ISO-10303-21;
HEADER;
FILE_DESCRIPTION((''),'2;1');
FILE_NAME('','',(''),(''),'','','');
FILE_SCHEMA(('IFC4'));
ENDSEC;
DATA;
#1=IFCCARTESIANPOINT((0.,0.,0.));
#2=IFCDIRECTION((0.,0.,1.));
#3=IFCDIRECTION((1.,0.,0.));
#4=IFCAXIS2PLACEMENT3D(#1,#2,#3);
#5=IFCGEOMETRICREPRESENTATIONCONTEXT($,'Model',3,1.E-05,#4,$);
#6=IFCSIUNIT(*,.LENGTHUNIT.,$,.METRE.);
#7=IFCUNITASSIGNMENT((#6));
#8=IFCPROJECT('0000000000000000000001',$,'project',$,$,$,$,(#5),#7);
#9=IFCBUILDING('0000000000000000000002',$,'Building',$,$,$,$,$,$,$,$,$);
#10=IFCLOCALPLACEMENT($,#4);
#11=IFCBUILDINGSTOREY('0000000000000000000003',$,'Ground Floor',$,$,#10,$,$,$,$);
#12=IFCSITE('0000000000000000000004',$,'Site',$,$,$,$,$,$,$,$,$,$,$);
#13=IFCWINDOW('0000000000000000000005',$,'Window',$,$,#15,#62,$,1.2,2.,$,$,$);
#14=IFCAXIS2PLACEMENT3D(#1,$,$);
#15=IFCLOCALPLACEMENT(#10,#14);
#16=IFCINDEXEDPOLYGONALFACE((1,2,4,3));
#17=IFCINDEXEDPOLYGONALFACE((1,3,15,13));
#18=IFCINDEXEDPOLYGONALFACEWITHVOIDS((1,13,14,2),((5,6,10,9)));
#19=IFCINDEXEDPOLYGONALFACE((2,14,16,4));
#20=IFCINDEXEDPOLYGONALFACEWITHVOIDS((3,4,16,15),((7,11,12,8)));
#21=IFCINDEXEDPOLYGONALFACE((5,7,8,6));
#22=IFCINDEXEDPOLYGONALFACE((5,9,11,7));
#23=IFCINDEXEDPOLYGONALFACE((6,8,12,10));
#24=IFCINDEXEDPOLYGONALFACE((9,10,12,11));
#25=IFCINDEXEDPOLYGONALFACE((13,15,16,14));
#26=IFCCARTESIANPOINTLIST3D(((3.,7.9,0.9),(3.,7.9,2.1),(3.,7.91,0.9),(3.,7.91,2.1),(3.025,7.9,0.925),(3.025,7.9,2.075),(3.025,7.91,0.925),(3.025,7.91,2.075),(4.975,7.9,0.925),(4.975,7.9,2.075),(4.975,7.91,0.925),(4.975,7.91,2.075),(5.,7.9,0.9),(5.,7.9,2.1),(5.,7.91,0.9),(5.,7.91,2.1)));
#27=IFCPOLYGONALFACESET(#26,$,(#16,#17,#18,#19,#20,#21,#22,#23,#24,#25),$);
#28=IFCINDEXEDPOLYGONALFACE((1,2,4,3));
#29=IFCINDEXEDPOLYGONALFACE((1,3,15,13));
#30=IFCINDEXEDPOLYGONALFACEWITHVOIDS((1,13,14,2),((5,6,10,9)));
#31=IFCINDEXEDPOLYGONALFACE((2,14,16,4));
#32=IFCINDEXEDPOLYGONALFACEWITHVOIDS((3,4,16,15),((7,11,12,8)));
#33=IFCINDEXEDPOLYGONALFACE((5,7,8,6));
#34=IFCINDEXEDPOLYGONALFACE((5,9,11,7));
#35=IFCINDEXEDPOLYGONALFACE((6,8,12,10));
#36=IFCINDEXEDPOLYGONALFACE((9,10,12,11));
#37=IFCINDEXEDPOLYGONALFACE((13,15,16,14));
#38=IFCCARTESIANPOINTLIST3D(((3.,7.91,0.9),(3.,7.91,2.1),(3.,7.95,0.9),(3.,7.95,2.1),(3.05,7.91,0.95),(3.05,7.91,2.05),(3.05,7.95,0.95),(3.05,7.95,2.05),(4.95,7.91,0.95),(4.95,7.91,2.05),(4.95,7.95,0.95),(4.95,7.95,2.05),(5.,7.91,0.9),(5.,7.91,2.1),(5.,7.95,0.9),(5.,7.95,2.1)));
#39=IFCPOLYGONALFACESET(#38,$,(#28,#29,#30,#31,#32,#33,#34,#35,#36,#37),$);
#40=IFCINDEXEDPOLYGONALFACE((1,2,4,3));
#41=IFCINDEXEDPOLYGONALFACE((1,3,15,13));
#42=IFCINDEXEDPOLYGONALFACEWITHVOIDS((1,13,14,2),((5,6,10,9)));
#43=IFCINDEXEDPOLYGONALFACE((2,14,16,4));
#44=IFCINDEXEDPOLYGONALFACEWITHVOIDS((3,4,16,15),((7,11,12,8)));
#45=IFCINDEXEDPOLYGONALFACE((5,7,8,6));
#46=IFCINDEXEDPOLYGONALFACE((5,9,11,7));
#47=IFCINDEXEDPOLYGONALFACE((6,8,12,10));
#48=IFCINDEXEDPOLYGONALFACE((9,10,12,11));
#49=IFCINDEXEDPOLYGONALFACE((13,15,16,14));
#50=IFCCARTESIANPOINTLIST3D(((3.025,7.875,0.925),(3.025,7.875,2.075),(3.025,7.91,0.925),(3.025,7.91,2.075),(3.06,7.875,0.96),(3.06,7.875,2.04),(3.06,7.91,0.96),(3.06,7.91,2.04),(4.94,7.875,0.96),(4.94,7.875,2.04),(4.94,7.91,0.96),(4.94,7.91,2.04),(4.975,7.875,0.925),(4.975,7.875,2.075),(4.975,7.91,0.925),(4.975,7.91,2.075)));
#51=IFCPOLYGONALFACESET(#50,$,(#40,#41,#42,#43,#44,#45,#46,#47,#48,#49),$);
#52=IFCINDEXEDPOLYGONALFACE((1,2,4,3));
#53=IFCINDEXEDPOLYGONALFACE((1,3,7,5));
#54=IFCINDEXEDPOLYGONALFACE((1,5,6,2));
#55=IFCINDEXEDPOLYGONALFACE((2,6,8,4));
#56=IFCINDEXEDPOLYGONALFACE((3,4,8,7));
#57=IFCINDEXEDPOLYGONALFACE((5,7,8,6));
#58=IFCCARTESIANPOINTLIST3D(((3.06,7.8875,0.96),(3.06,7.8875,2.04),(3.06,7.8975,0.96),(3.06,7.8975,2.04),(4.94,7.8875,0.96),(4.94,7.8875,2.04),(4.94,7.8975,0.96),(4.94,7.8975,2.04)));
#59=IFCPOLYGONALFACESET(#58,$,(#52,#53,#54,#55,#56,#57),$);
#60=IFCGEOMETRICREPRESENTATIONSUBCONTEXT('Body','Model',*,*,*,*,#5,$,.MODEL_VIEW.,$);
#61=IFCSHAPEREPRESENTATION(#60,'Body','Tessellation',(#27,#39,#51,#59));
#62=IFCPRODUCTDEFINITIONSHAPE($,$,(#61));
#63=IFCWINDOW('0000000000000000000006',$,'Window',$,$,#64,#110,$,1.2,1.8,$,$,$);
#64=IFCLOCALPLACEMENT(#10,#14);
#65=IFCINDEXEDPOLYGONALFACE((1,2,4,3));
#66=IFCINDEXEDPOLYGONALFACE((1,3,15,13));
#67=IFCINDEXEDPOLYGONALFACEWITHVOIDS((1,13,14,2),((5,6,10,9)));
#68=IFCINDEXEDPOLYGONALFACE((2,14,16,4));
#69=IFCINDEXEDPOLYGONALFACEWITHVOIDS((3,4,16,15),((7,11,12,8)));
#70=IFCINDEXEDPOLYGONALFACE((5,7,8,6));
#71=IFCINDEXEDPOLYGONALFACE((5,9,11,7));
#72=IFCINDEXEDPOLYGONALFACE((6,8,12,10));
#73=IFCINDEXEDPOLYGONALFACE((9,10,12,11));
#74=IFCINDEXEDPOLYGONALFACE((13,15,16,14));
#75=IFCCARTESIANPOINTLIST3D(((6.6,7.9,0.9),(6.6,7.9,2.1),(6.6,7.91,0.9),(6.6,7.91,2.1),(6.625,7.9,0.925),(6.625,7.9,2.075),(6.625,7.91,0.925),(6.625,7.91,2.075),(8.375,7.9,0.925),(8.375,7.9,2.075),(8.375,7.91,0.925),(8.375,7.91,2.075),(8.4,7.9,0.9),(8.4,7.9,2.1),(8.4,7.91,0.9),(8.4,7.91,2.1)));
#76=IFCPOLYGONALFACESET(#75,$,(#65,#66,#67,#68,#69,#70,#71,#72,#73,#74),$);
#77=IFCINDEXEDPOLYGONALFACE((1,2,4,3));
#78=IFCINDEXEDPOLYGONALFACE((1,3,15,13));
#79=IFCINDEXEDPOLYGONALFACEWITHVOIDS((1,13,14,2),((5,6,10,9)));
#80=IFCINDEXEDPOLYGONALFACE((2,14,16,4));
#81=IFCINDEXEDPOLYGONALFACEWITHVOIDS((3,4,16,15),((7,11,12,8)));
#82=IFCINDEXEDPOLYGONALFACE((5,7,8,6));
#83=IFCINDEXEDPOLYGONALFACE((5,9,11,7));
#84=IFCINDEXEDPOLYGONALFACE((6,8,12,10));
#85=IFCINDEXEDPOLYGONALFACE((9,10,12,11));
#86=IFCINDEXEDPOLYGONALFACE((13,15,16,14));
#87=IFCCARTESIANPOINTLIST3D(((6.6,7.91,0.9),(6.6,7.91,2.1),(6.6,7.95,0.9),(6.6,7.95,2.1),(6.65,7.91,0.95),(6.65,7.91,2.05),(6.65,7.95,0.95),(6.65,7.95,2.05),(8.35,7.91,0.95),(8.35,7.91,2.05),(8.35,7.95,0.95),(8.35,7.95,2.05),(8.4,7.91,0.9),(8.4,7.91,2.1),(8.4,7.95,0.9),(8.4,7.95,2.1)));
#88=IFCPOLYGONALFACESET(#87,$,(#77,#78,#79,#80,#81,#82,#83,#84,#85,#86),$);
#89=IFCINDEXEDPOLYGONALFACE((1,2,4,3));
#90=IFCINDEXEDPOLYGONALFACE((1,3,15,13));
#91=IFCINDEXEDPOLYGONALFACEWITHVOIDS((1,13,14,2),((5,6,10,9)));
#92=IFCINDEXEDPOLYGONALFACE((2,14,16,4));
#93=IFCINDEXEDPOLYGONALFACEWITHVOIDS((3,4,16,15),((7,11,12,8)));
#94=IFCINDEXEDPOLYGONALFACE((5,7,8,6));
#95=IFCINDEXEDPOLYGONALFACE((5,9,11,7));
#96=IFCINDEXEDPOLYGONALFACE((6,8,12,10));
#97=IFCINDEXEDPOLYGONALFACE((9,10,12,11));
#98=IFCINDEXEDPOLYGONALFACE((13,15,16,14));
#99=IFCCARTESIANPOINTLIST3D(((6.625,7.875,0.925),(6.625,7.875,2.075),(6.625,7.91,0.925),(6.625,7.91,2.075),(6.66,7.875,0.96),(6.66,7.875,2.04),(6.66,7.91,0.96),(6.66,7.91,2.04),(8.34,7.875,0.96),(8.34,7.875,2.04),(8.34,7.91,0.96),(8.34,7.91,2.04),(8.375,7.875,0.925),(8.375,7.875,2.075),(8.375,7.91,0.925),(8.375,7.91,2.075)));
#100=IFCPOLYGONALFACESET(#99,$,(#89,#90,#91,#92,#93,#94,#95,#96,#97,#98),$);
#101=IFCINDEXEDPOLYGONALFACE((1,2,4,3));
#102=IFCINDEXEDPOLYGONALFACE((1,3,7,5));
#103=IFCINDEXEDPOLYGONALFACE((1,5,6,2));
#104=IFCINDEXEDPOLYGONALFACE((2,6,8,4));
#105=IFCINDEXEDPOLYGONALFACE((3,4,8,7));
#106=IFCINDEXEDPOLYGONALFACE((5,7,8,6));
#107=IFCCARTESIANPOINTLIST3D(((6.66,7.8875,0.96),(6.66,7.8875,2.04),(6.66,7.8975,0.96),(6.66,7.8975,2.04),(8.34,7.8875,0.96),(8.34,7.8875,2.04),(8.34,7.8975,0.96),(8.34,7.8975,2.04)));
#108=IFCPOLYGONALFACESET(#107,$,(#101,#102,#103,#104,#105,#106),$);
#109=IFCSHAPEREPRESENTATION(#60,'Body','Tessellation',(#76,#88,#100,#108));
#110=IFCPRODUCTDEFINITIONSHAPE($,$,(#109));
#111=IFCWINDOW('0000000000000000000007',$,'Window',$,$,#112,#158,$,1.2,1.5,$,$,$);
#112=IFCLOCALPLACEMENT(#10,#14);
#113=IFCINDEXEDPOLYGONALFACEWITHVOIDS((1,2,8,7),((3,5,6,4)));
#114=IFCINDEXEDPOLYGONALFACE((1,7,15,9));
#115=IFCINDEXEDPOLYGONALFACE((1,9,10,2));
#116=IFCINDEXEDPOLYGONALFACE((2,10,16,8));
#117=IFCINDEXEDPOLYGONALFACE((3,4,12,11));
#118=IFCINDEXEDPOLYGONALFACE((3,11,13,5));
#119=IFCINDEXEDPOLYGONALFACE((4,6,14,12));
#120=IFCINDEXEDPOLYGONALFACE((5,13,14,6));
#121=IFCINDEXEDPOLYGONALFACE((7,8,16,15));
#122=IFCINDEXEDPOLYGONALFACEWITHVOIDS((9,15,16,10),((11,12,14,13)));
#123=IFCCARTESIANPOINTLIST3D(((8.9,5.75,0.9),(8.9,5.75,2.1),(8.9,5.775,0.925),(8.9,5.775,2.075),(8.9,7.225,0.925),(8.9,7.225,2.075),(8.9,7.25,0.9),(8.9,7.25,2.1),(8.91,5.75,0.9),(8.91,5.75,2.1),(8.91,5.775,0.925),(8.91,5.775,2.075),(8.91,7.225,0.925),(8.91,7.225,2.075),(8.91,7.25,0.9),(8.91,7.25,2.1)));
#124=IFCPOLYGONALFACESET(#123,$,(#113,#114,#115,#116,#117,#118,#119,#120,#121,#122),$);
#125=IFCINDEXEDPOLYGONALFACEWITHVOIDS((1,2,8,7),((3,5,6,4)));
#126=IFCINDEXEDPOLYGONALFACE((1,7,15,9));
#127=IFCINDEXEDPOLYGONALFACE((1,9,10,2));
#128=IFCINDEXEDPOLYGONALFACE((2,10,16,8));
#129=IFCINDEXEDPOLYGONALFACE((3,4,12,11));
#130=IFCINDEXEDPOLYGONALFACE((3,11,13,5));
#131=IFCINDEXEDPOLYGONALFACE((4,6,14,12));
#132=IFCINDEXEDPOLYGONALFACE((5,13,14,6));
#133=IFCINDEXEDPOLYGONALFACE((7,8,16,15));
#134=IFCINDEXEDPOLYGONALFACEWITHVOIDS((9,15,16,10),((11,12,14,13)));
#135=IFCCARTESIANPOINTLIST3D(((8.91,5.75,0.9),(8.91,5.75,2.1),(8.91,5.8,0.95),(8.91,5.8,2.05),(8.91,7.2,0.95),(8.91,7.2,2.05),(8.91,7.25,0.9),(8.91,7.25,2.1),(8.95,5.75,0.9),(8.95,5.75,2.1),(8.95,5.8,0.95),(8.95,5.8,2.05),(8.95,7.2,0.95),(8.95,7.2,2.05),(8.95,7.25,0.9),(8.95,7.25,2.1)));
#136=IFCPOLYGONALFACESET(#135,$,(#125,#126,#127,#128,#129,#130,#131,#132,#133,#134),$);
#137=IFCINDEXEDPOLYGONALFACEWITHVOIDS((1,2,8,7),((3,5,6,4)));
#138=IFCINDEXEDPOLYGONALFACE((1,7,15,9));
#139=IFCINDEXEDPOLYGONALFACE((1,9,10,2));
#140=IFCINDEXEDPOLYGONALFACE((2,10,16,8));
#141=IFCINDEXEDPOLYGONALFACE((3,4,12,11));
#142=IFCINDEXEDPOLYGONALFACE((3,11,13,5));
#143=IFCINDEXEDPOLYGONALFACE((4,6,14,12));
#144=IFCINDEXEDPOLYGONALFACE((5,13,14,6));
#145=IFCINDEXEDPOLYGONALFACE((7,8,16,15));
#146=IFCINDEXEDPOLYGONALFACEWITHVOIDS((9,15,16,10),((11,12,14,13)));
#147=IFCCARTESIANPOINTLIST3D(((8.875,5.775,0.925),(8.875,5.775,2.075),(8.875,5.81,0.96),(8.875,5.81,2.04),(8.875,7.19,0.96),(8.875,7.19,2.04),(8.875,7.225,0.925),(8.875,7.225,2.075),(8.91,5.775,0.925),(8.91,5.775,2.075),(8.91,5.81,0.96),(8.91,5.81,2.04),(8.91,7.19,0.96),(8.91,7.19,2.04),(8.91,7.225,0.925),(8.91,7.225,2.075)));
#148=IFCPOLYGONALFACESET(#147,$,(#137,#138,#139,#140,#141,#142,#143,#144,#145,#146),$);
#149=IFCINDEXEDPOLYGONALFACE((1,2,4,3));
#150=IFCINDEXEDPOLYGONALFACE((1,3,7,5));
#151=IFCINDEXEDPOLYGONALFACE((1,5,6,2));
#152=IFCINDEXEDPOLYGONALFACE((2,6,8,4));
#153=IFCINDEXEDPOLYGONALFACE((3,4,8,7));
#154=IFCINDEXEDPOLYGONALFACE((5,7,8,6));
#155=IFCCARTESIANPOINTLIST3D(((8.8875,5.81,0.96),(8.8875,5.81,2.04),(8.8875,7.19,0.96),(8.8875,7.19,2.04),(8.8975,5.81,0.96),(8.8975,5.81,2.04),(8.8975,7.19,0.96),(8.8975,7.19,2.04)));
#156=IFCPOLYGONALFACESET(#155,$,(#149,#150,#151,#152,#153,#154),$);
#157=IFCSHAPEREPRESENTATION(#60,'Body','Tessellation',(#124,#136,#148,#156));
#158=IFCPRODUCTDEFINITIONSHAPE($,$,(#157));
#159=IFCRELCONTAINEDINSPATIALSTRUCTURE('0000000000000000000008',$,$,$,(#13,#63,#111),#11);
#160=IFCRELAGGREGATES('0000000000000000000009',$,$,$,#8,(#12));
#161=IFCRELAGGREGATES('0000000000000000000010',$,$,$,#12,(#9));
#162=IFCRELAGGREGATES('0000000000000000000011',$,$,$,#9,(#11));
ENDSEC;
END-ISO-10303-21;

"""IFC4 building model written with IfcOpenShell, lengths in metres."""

from ifc_helpers import new_model, si_unit, frame, origin_with_axes, place, context, subcontext, project, spatial, line, indexed_curve, outline, extrude, element, save


model = new_model("IFC4")

# Units and contexts
model_context = context("Model", 3, precision=1e-05, world=origin_with_axes())
body_context = subcontext(model_context, "Body", "Model", "MODEL_VIEW")
ifc_project = project(units=[si_unit("LENGTHUNIT", "METRE")], contexts=[model_context])

# Site, building, storey
site = spatial("IfcSite", under=ifc_project, Name="Site")
building = spatial("IfcBuilding", under=site, Name="Building")
storey_placement = place(None, origin_with_axes())
storey = spatial("IfcBuildingStorey", under=building, at=storey_placement, Name="Ground Floor")

# Windows
window_1_placement = place(storey_placement, frame((5.0, 8.0, 0.9), z_axis=(0.0, 0.0, 1.0), x_axis=(-1.0, 0.0, 0.0)))
element("IfcWindow", 1, at=window_1_placement, inside=storey, Name="Window", OverallHeight=1.2, OverallWidth=2.0, context=body_context, shape_type="SweptSolid", body=[
    extrude(outline(indexed_curve([(0.0, 0.0), (2.0, 0.0), (2.0, 1.2), (0.0, 1.2)], segments=[line(1, 2, 3, 4, 1)]), holes=[indexed_curve([(0.025, 0.025), (1.975, 0.025), (1.975, 1.175), (0.025, 1.175)], segments=[line(1, 2, 3, 4, 1)])]), frame((0.0, 0.09, 0.0), z_axis=(0.0, -1.0, 0.0), x_axis=(1.0, 0.0, 0.0)), (0.0, 0.0, -1.0), 0.01),
    extrude(outline(indexed_curve([(0.0, 0.0), (2.0, 0.0), (2.0, 1.2), (0.0, 1.2)], segments=[line(1, 2, 3, 4, 1)]), holes=[indexed_curve([(0.05, 0.05), (1.95, 0.05), (1.95, 1.15), (0.05, 1.15)], segments=[line(1, 2, 3, 4, 1)])]), frame((0.0, 0.05, 0.0), z_axis=(0.0, -1.0, 0.0), x_axis=(1.0, 0.0, 0.0)), (0.0, 0.0, -1.0), 0.04),
    extrude(outline(indexed_curve([(0.0, 0.0), (1.95, 0.0), (1.95, 1.15), (0.0, 1.15)], segments=[line(1, 2, 3, 4, 1)]), holes=[indexed_curve([(0.035, 0.035), (1.915, 0.035), (1.915, 1.115), (0.035, 1.115)], segments=[line(1, 2, 3, 4, 1)])]), frame((0.025, 0.09, 0.025), z_axis=(0.0, -1.0, 0.0), x_axis=(1.0, 0.0, 0.0)), (0.0, 0.0, -1.0), 0.035),
    extrude(outline(indexed_curve([(0.035, 0.035), (1.915, 0.035), (1.915, 1.115), (0.035, 1.115)], segments=[line(1, 2, 3, 4, 1)])), frame((0.025, 0.1025, 0.025), z_axis=(0.0, -1.0, 0.0), x_axis=(1.0, 0.0, 0.0)), (0.0, 0.0, -1.0), 0.01),
])
window_2_placement = place(storey_placement, frame((8.4, 8.0, 0.9), z_axis=(0.0, 0.0, 1.0), x_axis=(-1.0, 0.0, 0.0)))
element("IfcWindow", 2, at=window_2_placement, inside=storey, Name="Window", OverallHeight=1.2, OverallWidth=1.8, context=body_context, shape_type="SweptSolid", body=[
    extrude(outline(indexed_curve([(0.0, 0.0), (1.8, 0.0), (1.8, 1.2), (0.0, 1.2)], segments=[line(1, 2, 3, 4, 1)]), holes=[indexed_curve([(0.025, 0.025), (1.775, 0.025), (1.775, 1.175), (0.025, 1.175)], segments=[line(1, 2, 3, 4, 1)])]), frame((0.0, 0.09, 0.0), z_axis=(0.0, -1.0, 0.0), x_axis=(1.0, 0.0, 0.0)), (0.0, 0.0, -1.0), 0.01),
    extrude(outline(indexed_curve([(0.0, 0.0), (1.8, 0.0), (1.8, 1.2), (0.0, 1.2)], segments=[line(1, 2, 3, 4, 1)]), holes=[indexed_curve([(0.05, 0.05), (1.75, 0.05), (1.75, 1.15), (0.05, 1.15)], segments=[line(1, 2, 3, 4, 1)])]), frame((0.0, 0.05, 0.0), z_axis=(0.0, -1.0, 0.0), x_axis=(1.0, 0.0, 0.0)), (0.0, 0.0, -1.0), 0.04),
    extrude(outline(indexed_curve([(0.0, 0.0), (1.75, 0.0), (1.75, 1.15), (0.0, 1.15)], segments=[line(1, 2, 3, 4, 1)]), holes=[indexed_curve([(0.035, 0.035), (1.715, 0.035), (1.715, 1.115), (0.035, 1.115)], segments=[line(1, 2, 3, 4, 1)])]), frame((0.025, 0.09, 0.025), z_axis=(0.0, -1.0, 0.0), x_axis=(1.0, 0.0, 0.0)), (0.0, 0.0, -1.0), 0.035),
    extrude(outline(indexed_curve([(0.035, 0.035), (1.715, 0.035), (1.715, 1.115), (0.035, 1.115)], segments=[line(1, 2, 3, 4, 1)])), frame((0.025, 0.1025, 0.025), z_axis=(0.0, -1.0, 0.0), x_axis=(1.0, 0.0, 0.0)), (0.0, 0.0, -1.0), 0.01),
])
window_3_placement = place(storey_placement, frame((9.0, 5.75, 0.9), z_axis=(0.0, 0.0, 1.0), x_axis=(0.0, 1.0, 0.0)))
element("IfcWindow", 3, at=window_3_placement, inside=storey, Name="Window", OverallHeight=1.2, OverallWidth=1.5, context=body_context, shape_type="SweptSolid", body=[
    extrude(outline(indexed_curve([(0.0, 0.0), (1.5, 0.0), (1.5, 1.2), (0.0, 1.2)], segments=[line(1, 2, 3, 4, 1)]), holes=[indexed_curve([(0.025, 0.025), (1.475, 0.025), (1.475, 1.175), (0.025, 1.175)], segments=[line(1, 2, 3, 4, 1)])]), frame((0.0, 0.09, 0.0), z_axis=(0.0, -1.0, 0.0), x_axis=(1.0, 0.0, 0.0)), (0.0, 0.0, -1.0), 0.01),
    extrude(outline(indexed_curve([(0.0, 0.0), (1.5, 0.0), (1.5, 1.2), (0.0, 1.2)], segments=[line(1, 2, 3, 4, 1)]), holes=[indexed_curve([(0.05, 0.05), (1.45, 0.05), (1.45, 1.15), (0.05, 1.15)], segments=[line(1, 2, 3, 4, 1)])]), frame((0.0, 0.05, 0.0), z_axis=(0.0, -1.0, 0.0), x_axis=(1.0, 0.0, 0.0)), (0.0, 0.0, -1.0), 0.04),
    extrude(outline(indexed_curve([(0.0, 0.0), (1.45, 0.0), (1.45, 1.15), (0.0, 1.15)], segments=[line(1, 2, 3, 4, 1)]), holes=[indexed_curve([(0.035, 0.035), (1.415, 0.035), (1.415, 1.115), (0.035, 1.115)], segments=[line(1, 2, 3, 4, 1)])]), frame((0.025, 0.09, 0.025), z_axis=(0.0, -1.0, 0.0), x_axis=(1.0, 0.0, 0.0)), (0.0, 0.0, -1.0), 0.035),
    extrude(outline(indexed_curve([(0.035, 0.035), (1.415, 0.035), (1.415, 1.115), (0.035, 1.115)], segments=[line(1, 2, 3, 4, 1)])), frame((0.025, 0.1025, 0.025), z_axis=(0.0, -1.0, 0.0), x_axis=(1.0, 0.0, 0.0)), (0.0, 0.0, -1.0), 0.01),
])

save(model, "model.ifc")
